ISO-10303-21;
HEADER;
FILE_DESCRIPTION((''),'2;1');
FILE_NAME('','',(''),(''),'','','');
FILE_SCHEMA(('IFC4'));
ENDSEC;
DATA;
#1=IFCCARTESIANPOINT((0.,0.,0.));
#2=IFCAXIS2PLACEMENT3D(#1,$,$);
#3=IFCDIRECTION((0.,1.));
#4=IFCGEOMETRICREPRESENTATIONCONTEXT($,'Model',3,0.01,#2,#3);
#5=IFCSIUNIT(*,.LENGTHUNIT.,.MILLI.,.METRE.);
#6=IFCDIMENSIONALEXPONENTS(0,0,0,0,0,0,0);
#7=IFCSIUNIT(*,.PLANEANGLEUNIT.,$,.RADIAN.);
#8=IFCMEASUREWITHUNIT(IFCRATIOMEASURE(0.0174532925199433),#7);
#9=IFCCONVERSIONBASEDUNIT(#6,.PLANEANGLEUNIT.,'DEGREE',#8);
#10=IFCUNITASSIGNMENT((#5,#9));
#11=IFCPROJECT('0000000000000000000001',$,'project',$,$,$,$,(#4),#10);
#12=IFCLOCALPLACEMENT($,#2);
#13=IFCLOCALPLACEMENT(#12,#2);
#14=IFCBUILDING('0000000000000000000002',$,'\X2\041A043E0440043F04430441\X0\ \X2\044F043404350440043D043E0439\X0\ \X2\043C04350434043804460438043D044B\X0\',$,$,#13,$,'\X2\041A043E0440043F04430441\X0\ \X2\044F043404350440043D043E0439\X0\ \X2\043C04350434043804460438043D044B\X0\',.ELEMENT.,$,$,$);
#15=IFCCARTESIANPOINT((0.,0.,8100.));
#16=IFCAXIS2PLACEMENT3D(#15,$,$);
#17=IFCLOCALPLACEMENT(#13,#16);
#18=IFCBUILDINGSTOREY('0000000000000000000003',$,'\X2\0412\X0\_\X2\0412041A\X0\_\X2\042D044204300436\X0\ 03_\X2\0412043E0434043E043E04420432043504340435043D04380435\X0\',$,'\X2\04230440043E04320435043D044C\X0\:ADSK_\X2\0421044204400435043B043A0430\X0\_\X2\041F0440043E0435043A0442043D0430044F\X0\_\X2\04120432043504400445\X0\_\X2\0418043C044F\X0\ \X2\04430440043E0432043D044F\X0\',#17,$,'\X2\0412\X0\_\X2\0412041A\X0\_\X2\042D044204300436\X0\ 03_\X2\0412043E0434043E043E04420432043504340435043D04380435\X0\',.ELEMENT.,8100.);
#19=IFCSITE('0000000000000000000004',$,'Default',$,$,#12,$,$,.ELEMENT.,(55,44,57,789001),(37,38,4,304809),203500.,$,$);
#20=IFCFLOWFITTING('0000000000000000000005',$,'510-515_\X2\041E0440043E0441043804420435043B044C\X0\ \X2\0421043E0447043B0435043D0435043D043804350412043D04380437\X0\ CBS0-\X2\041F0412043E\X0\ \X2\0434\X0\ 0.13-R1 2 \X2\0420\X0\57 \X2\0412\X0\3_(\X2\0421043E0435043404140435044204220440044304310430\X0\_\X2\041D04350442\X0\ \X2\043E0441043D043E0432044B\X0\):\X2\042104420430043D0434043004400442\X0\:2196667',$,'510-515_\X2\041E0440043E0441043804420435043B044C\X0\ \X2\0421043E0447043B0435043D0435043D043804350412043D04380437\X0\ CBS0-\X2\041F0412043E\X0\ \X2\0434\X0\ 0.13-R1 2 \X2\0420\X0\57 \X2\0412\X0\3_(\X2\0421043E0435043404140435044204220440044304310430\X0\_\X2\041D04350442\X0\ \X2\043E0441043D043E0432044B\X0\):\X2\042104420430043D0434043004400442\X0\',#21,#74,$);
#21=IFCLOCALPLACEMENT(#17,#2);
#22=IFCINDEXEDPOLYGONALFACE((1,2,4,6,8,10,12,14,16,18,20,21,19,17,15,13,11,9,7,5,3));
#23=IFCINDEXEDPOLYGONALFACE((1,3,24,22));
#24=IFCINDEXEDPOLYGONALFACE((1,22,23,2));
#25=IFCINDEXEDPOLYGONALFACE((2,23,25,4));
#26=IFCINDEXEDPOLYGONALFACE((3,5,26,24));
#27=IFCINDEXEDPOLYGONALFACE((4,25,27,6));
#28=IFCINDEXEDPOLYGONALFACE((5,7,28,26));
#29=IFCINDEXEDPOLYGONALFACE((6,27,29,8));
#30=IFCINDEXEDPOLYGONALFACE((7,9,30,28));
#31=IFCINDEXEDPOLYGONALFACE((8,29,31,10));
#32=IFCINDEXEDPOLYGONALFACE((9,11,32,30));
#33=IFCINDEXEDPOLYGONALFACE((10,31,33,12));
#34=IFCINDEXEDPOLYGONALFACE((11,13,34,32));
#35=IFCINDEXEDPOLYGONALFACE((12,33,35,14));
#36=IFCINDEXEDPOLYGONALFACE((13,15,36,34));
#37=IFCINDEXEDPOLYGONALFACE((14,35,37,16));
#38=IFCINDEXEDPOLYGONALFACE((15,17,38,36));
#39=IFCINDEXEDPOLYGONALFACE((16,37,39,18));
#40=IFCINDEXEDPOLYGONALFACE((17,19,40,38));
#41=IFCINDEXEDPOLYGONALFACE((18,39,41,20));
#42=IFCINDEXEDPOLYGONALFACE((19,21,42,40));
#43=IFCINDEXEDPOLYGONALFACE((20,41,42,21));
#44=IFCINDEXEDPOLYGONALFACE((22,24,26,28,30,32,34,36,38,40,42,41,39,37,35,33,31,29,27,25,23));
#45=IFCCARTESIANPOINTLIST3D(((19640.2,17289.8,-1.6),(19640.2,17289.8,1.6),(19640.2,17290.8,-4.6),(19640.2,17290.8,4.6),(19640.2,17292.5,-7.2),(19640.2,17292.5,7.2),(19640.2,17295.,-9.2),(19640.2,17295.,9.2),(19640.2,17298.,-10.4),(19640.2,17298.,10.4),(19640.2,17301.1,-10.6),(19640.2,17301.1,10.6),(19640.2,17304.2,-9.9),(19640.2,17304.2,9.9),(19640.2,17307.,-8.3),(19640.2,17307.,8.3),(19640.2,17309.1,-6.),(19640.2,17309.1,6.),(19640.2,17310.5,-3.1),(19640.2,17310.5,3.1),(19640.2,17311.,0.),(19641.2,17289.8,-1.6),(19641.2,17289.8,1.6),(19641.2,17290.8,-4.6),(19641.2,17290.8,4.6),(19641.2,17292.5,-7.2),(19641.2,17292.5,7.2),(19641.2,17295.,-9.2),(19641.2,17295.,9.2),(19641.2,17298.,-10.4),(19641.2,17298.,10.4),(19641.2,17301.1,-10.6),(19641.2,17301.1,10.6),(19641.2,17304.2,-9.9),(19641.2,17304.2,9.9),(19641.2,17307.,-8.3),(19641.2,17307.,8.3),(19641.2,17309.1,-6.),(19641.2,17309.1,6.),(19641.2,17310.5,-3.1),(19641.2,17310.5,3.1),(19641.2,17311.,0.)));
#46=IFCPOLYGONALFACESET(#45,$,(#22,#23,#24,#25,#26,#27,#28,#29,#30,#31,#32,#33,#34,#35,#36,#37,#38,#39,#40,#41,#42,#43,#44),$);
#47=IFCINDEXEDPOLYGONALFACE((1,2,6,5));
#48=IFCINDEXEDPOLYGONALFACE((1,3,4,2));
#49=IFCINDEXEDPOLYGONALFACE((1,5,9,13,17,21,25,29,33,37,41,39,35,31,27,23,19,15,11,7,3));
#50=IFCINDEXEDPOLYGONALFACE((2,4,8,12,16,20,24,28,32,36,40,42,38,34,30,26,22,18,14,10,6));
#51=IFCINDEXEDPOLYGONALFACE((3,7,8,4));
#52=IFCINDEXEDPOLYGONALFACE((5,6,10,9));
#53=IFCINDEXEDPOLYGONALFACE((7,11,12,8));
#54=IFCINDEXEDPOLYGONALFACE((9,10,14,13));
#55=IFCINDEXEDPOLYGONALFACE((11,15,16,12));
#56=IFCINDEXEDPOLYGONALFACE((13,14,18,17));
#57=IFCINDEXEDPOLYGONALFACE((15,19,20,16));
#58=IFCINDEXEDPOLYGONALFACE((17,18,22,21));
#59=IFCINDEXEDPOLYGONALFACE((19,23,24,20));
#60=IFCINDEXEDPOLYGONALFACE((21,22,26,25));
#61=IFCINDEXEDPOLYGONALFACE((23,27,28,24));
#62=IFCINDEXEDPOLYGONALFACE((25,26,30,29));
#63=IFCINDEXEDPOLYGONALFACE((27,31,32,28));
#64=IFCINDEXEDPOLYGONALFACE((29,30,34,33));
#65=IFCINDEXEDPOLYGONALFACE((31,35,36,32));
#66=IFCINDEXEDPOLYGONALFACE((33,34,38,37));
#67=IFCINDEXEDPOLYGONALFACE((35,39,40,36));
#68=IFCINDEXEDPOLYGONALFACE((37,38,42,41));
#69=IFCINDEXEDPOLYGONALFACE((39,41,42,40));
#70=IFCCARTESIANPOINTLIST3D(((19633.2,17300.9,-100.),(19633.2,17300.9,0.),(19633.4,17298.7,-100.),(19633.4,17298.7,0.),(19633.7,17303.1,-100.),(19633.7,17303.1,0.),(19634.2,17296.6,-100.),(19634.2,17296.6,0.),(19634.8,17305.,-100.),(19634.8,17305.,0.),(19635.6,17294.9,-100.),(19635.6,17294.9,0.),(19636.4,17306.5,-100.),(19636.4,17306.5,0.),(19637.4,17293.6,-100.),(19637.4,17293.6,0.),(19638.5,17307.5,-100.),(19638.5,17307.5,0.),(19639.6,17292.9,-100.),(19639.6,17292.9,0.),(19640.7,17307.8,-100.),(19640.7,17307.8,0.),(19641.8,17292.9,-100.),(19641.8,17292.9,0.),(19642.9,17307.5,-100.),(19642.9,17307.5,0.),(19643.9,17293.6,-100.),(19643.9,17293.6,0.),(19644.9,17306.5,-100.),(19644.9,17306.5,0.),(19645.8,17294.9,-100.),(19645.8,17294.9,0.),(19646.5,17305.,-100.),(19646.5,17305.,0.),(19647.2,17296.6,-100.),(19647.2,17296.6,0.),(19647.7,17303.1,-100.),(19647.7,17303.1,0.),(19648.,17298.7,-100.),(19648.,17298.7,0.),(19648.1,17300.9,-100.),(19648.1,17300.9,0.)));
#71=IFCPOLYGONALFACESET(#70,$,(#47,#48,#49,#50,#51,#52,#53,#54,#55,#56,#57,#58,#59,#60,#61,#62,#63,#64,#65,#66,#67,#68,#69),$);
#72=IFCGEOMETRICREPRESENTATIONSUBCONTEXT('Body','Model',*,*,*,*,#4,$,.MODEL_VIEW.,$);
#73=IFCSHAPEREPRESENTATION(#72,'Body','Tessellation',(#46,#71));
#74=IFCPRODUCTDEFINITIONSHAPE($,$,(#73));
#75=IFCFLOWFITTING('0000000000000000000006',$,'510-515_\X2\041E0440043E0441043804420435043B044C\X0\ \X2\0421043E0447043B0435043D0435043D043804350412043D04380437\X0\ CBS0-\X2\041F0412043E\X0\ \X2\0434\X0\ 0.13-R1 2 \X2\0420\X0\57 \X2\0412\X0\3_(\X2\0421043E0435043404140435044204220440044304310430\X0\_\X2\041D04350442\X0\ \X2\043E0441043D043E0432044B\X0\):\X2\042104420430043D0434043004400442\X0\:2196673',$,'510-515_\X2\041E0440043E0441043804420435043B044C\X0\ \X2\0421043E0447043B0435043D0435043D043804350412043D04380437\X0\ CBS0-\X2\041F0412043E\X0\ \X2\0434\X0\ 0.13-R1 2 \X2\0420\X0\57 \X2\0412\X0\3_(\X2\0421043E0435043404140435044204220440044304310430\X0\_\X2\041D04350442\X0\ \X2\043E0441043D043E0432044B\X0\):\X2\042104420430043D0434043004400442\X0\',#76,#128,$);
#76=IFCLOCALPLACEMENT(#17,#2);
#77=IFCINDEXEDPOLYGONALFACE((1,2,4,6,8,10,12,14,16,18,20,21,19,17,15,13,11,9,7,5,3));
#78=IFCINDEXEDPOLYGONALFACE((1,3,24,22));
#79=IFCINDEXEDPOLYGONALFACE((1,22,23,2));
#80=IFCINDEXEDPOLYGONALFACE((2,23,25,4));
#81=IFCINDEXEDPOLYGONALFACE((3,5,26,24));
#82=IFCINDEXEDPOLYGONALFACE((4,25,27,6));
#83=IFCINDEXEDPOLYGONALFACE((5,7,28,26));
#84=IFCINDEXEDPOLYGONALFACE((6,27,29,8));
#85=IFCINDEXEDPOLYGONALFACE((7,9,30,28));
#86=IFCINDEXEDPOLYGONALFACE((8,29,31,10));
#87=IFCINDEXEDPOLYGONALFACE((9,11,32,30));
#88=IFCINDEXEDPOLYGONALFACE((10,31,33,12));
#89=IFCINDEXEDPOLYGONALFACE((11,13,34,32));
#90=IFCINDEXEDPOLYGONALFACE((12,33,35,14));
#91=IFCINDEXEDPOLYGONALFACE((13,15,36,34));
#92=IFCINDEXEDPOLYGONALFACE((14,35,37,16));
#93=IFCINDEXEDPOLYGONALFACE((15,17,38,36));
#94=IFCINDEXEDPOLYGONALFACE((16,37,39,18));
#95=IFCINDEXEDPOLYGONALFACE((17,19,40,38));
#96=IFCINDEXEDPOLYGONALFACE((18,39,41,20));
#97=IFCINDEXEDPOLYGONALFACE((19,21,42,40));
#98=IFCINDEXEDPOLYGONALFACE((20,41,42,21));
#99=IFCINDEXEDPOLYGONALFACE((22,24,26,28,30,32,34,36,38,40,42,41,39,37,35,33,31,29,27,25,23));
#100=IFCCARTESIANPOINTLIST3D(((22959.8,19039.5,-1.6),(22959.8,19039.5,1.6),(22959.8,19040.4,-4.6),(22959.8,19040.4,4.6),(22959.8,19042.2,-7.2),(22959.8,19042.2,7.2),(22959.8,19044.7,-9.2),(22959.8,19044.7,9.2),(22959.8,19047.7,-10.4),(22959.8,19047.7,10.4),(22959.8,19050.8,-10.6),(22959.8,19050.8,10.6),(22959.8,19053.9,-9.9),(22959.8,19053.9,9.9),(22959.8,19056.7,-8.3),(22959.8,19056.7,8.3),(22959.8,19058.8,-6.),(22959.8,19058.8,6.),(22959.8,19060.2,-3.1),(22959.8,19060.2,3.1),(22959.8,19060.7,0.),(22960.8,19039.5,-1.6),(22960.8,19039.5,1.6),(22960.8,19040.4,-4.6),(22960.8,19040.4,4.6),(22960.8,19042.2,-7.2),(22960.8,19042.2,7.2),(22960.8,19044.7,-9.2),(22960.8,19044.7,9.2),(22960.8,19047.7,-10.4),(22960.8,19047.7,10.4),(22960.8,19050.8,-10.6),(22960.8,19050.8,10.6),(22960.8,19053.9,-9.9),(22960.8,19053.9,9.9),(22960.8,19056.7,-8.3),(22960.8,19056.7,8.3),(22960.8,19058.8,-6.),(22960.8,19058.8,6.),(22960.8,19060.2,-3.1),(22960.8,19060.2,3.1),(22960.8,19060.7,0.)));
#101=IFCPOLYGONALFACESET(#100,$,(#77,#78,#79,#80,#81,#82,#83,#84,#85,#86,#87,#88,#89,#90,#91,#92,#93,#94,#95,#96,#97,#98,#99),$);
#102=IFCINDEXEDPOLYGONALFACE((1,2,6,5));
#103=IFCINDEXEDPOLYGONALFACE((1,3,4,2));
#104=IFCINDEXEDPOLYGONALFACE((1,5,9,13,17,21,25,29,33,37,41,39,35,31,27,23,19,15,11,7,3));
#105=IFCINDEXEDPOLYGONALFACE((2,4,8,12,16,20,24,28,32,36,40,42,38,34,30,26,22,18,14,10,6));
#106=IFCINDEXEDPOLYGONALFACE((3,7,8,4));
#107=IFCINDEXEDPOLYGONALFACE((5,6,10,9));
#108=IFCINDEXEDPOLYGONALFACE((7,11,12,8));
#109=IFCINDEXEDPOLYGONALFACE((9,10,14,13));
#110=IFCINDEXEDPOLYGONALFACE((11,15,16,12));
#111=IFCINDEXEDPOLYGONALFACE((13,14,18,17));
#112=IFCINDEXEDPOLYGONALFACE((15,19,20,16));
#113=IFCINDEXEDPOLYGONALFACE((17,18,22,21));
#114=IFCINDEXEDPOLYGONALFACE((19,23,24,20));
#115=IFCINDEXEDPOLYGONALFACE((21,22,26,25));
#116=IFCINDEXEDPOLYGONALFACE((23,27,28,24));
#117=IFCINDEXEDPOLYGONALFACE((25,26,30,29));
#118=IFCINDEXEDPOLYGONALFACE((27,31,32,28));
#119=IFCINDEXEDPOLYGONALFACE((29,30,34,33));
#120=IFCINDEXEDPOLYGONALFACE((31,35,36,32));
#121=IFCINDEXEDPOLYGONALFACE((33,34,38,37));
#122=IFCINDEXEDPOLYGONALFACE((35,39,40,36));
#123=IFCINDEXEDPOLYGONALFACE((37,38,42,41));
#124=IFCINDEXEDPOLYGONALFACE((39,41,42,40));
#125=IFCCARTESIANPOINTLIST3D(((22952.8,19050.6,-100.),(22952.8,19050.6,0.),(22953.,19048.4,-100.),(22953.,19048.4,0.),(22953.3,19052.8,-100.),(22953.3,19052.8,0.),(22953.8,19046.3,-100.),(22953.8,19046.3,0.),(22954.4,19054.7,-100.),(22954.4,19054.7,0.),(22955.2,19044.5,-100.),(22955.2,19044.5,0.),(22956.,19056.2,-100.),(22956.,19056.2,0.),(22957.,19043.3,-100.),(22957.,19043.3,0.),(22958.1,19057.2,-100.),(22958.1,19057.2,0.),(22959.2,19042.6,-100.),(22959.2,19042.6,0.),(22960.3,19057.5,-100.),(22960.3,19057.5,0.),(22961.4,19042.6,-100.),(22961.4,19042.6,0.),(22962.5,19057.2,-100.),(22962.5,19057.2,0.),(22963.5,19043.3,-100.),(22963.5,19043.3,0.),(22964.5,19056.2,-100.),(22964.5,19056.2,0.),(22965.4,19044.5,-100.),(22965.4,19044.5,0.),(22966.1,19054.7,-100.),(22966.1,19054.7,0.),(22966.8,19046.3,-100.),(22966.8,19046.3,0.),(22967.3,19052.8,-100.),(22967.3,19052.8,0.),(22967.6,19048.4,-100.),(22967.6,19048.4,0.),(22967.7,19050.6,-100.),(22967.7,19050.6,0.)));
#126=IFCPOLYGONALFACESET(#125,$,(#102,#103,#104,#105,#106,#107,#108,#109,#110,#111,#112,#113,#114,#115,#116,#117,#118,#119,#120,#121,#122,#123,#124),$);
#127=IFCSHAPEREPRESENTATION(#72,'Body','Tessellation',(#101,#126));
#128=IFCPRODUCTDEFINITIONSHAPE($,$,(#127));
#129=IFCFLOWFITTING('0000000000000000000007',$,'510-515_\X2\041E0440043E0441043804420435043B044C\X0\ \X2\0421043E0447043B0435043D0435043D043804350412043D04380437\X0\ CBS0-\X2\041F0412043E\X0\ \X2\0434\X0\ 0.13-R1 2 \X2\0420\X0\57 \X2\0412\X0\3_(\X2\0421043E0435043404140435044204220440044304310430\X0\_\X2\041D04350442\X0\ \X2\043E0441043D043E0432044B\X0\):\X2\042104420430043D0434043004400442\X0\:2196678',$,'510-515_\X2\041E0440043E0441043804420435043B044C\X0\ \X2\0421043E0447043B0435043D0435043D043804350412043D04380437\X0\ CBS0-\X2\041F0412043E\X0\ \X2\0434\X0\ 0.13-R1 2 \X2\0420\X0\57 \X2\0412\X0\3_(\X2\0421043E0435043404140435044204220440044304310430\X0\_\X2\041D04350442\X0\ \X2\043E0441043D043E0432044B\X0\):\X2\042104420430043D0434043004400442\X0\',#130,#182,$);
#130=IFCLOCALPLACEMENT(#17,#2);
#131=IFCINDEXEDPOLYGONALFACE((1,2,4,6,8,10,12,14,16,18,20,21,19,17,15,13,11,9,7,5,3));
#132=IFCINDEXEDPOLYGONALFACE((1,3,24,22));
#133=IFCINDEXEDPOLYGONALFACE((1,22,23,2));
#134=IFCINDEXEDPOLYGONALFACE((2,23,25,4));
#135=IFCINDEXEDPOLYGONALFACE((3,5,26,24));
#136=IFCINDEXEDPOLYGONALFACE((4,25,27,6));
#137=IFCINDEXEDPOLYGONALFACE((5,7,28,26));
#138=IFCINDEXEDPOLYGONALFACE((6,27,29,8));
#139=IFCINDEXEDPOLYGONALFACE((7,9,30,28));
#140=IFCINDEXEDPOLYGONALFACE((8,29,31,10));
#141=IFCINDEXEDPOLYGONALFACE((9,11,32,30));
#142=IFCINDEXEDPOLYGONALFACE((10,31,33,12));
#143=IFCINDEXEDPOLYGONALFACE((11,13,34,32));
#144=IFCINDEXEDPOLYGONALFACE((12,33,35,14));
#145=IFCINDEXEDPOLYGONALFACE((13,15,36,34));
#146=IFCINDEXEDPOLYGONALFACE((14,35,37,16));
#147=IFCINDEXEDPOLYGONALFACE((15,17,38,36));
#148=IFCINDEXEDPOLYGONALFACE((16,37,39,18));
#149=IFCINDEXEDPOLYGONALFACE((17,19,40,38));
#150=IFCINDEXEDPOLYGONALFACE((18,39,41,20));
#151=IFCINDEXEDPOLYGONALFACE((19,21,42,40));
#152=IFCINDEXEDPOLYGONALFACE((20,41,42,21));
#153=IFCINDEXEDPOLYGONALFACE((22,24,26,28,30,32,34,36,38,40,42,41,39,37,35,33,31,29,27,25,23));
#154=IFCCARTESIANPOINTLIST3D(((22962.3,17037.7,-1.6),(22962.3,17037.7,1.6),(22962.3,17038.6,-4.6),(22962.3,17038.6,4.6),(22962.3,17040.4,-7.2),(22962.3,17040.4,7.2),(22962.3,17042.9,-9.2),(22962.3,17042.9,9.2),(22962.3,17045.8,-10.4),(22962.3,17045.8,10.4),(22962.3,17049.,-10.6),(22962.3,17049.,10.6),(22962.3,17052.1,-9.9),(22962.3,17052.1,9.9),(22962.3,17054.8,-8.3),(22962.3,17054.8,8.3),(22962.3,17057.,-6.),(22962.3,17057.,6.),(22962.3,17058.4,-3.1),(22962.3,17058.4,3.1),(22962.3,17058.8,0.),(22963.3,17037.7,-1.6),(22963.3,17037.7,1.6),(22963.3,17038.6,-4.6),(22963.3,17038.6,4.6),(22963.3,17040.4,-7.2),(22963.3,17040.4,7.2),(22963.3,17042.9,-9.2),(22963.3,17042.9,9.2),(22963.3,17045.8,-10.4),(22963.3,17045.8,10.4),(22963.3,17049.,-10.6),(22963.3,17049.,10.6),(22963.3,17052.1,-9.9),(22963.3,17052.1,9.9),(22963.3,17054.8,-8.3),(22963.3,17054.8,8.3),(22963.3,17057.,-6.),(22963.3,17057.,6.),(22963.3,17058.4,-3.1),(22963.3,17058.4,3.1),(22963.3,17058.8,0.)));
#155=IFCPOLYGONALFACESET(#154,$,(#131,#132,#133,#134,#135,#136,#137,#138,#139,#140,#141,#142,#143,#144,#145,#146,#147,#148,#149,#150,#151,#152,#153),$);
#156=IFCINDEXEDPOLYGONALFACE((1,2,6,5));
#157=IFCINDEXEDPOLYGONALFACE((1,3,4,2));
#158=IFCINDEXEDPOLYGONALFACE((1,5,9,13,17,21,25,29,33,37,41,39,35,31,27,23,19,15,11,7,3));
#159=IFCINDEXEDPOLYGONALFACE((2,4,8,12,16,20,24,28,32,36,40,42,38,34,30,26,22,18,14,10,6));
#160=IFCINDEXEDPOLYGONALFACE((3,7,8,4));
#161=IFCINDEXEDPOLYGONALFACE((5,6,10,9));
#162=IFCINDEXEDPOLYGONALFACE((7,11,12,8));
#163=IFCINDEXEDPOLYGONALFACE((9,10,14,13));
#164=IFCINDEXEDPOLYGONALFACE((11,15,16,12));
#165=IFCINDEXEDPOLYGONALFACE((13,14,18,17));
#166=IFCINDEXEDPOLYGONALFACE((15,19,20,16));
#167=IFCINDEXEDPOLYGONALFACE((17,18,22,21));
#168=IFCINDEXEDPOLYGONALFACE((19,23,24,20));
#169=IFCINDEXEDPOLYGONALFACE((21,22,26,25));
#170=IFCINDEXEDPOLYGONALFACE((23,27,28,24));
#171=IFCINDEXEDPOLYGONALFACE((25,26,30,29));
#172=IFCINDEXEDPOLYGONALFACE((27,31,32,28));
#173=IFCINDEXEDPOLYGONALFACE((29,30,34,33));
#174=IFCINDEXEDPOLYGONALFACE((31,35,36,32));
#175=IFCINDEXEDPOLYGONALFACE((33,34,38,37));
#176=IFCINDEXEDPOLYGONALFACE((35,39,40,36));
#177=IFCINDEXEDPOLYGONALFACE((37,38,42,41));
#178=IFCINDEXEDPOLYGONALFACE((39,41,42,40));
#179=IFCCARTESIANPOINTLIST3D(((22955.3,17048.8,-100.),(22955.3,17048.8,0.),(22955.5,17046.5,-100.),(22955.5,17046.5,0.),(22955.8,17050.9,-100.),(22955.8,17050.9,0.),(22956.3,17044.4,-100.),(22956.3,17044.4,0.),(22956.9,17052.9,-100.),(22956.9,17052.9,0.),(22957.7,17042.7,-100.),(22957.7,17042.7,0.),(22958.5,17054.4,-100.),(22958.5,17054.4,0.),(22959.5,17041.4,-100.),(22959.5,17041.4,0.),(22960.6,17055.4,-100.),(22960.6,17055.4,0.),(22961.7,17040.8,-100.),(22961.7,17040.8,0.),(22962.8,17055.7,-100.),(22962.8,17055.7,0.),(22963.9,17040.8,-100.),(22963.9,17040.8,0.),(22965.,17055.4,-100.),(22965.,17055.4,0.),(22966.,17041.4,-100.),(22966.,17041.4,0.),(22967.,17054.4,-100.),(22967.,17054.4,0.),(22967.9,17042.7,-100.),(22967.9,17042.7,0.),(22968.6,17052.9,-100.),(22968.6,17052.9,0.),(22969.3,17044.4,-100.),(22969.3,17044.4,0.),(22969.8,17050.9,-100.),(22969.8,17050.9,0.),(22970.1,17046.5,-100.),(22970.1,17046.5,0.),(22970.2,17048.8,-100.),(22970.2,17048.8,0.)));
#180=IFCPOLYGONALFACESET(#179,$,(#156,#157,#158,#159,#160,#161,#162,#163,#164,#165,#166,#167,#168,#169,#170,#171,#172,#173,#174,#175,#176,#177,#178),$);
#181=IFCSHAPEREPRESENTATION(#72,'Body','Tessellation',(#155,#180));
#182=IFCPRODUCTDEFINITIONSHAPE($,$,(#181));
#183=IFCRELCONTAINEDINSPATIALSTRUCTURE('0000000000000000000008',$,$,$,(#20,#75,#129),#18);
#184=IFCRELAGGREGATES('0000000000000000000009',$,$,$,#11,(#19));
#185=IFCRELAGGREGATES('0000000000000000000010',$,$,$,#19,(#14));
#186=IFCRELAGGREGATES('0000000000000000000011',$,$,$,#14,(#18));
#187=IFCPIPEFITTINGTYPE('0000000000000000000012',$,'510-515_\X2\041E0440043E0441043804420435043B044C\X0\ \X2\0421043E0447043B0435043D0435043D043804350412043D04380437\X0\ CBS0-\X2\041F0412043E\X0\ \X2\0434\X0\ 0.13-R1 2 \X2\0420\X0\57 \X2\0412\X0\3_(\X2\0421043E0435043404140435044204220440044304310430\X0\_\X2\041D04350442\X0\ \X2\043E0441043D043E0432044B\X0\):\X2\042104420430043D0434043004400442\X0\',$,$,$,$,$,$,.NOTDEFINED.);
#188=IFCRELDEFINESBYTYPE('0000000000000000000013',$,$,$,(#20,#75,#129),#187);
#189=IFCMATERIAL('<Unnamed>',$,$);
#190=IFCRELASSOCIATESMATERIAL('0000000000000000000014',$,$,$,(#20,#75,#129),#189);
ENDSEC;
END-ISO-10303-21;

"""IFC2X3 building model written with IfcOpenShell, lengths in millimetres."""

from ifc_helpers import new_model, entity, si_unit, converted_unit, direction, frame, origin, origin_2d_with_axis, place, context, subcontext, project, spatial, circle, extrude, source, transform, mapped, material, type_object, type_shapes, element, save


model = new_model("IFC2X3")

# Units and contexts
model_context = context("Model", 3, precision=0.01, world=origin(), true_north=direction((0.0, 1.0)))
body_context = subcontext(model_context, "Body", "Model", "MODEL_VIEW")
ifc_project = project(units=[si_unit("LENGTHUNIT", "METRE", prefix="MILLI"), converted_unit("PLANEANGLEUNIT", "DEGREE", entity("IfcRatioMeasure", 0.0174532925199433), si_unit("PLANEANGLEUNIT", "RADIAN"), dimensions=[0, 0, 0, 0, 0, 0, 0])], contexts=[model_context])

# Site, building, storey
site_placement = place(None, origin())
site = spatial("IfcSite", under=ifc_project, at=site_placement, Name="Default", CompositionType="ELEMENT", RefLatitude=(55, 44, 57, 789001), RefLongitude=(37, 38, 4, 304809), RefElevation=203500.0)
building_placement = place(site_placement, origin())
building = spatial("IfcBuilding", under=site, at=building_placement, Name="Корпус ядерной медицины", LongName="Корпус ядерной медицины", CompositionType="ELEMENT")
storey_placement = place(building_placement, frame((0.0, 0.0, 8100.0)))
storey = spatial("IfcBuildingStorey", under=building, at=storey_placement, Name="В_ВК_Этаж 03_Водоотведение", ObjectType="Уровень:ADSK_Стрелка_Проектная_Вверх_Имя уровня", LongName="В_ВК_Этаж 03_Водоотведение", CompositionType="ELEMENT", Elevation=8100.0)

# Flow fittings
ifc_material_1 = material(Name="<Unnamed>")
pipe_fitting_type_1 = type_object("IfcPipeFittingType", Name="510-515_Ороситель СочленениеВниз CBS0-ПВо д 0.13-R1 2 Р57 В3_(СоедДетТруба_Нет основы):Стандарт", PredefinedType="NOTDEFINED")
shared_shape_1 = source(origin(), body_context, "Body", "SweptSolid", [
    extrude(circle(Radius=10.7, at=origin_2d_with_axis()), frame((-0.5, 0.0, 0.0), z_axis=(1.0, 0.0, 0.0), x_axis=(0.0, 1.0, 0.0)), (0.0, 0.0, 1.0), 1.0),
    extrude(circle(Radius=7.5, at=origin_2d_with_axis()), frame((0.0, 0.0, -100.0), z_axis=(0.0, 0.0, 1.0), x_axis=(0.0, 1.0, 0.0)), (0.0, 0.0, 1.0), 100.0),
])
type_shapes(pipe_fitting_type_1, [shared_shape_1])
for number, where, name in (
    (1, (19640.7, 17300.3, 0.0), "510-515_Ороситель СочленениеВниз CBS0-ПВо д 0.13-R1 2 Р57 В3_(СоедДетТруба_Нет основы):Стандарт:2196667"),
    (2, (22960.3, 19050.0, 0.0), "510-515_Ороситель СочленениеВниз CBS0-ПВо д 0.13-R1 2 Р57 В3_(СоедДетТруба_Нет основы):Стандарт:2196673"),
    (3, (22962.8, 17048.2, 0.0), "510-515_Ороситель СочленениеВниз CBS0-ПВо д 0.13-R1 2 Р57 В3_(СоедДетТруба_Нет основы):Стандарт:2196678"),
):
    element("IfcFlowFitting", number, at=place(storey_placement, frame(where)), inside=storey, type_object=pipe_fitting_type_1, material=ifc_material_1, Name=name, ObjectType="510-515_Ороситель СочленениеВниз CBS0-ПВо д 0.13-R1 2 Р57 В3_(СоедДетТруба_Нет основы):Стандарт", context=body_context, shape_type="MappedRepresentation", body=[
        mapped(shared_shape_1, transform((0.0, 0.0, 0.0), scale=1.0)),
    ])

save(model, "model.ifc")
